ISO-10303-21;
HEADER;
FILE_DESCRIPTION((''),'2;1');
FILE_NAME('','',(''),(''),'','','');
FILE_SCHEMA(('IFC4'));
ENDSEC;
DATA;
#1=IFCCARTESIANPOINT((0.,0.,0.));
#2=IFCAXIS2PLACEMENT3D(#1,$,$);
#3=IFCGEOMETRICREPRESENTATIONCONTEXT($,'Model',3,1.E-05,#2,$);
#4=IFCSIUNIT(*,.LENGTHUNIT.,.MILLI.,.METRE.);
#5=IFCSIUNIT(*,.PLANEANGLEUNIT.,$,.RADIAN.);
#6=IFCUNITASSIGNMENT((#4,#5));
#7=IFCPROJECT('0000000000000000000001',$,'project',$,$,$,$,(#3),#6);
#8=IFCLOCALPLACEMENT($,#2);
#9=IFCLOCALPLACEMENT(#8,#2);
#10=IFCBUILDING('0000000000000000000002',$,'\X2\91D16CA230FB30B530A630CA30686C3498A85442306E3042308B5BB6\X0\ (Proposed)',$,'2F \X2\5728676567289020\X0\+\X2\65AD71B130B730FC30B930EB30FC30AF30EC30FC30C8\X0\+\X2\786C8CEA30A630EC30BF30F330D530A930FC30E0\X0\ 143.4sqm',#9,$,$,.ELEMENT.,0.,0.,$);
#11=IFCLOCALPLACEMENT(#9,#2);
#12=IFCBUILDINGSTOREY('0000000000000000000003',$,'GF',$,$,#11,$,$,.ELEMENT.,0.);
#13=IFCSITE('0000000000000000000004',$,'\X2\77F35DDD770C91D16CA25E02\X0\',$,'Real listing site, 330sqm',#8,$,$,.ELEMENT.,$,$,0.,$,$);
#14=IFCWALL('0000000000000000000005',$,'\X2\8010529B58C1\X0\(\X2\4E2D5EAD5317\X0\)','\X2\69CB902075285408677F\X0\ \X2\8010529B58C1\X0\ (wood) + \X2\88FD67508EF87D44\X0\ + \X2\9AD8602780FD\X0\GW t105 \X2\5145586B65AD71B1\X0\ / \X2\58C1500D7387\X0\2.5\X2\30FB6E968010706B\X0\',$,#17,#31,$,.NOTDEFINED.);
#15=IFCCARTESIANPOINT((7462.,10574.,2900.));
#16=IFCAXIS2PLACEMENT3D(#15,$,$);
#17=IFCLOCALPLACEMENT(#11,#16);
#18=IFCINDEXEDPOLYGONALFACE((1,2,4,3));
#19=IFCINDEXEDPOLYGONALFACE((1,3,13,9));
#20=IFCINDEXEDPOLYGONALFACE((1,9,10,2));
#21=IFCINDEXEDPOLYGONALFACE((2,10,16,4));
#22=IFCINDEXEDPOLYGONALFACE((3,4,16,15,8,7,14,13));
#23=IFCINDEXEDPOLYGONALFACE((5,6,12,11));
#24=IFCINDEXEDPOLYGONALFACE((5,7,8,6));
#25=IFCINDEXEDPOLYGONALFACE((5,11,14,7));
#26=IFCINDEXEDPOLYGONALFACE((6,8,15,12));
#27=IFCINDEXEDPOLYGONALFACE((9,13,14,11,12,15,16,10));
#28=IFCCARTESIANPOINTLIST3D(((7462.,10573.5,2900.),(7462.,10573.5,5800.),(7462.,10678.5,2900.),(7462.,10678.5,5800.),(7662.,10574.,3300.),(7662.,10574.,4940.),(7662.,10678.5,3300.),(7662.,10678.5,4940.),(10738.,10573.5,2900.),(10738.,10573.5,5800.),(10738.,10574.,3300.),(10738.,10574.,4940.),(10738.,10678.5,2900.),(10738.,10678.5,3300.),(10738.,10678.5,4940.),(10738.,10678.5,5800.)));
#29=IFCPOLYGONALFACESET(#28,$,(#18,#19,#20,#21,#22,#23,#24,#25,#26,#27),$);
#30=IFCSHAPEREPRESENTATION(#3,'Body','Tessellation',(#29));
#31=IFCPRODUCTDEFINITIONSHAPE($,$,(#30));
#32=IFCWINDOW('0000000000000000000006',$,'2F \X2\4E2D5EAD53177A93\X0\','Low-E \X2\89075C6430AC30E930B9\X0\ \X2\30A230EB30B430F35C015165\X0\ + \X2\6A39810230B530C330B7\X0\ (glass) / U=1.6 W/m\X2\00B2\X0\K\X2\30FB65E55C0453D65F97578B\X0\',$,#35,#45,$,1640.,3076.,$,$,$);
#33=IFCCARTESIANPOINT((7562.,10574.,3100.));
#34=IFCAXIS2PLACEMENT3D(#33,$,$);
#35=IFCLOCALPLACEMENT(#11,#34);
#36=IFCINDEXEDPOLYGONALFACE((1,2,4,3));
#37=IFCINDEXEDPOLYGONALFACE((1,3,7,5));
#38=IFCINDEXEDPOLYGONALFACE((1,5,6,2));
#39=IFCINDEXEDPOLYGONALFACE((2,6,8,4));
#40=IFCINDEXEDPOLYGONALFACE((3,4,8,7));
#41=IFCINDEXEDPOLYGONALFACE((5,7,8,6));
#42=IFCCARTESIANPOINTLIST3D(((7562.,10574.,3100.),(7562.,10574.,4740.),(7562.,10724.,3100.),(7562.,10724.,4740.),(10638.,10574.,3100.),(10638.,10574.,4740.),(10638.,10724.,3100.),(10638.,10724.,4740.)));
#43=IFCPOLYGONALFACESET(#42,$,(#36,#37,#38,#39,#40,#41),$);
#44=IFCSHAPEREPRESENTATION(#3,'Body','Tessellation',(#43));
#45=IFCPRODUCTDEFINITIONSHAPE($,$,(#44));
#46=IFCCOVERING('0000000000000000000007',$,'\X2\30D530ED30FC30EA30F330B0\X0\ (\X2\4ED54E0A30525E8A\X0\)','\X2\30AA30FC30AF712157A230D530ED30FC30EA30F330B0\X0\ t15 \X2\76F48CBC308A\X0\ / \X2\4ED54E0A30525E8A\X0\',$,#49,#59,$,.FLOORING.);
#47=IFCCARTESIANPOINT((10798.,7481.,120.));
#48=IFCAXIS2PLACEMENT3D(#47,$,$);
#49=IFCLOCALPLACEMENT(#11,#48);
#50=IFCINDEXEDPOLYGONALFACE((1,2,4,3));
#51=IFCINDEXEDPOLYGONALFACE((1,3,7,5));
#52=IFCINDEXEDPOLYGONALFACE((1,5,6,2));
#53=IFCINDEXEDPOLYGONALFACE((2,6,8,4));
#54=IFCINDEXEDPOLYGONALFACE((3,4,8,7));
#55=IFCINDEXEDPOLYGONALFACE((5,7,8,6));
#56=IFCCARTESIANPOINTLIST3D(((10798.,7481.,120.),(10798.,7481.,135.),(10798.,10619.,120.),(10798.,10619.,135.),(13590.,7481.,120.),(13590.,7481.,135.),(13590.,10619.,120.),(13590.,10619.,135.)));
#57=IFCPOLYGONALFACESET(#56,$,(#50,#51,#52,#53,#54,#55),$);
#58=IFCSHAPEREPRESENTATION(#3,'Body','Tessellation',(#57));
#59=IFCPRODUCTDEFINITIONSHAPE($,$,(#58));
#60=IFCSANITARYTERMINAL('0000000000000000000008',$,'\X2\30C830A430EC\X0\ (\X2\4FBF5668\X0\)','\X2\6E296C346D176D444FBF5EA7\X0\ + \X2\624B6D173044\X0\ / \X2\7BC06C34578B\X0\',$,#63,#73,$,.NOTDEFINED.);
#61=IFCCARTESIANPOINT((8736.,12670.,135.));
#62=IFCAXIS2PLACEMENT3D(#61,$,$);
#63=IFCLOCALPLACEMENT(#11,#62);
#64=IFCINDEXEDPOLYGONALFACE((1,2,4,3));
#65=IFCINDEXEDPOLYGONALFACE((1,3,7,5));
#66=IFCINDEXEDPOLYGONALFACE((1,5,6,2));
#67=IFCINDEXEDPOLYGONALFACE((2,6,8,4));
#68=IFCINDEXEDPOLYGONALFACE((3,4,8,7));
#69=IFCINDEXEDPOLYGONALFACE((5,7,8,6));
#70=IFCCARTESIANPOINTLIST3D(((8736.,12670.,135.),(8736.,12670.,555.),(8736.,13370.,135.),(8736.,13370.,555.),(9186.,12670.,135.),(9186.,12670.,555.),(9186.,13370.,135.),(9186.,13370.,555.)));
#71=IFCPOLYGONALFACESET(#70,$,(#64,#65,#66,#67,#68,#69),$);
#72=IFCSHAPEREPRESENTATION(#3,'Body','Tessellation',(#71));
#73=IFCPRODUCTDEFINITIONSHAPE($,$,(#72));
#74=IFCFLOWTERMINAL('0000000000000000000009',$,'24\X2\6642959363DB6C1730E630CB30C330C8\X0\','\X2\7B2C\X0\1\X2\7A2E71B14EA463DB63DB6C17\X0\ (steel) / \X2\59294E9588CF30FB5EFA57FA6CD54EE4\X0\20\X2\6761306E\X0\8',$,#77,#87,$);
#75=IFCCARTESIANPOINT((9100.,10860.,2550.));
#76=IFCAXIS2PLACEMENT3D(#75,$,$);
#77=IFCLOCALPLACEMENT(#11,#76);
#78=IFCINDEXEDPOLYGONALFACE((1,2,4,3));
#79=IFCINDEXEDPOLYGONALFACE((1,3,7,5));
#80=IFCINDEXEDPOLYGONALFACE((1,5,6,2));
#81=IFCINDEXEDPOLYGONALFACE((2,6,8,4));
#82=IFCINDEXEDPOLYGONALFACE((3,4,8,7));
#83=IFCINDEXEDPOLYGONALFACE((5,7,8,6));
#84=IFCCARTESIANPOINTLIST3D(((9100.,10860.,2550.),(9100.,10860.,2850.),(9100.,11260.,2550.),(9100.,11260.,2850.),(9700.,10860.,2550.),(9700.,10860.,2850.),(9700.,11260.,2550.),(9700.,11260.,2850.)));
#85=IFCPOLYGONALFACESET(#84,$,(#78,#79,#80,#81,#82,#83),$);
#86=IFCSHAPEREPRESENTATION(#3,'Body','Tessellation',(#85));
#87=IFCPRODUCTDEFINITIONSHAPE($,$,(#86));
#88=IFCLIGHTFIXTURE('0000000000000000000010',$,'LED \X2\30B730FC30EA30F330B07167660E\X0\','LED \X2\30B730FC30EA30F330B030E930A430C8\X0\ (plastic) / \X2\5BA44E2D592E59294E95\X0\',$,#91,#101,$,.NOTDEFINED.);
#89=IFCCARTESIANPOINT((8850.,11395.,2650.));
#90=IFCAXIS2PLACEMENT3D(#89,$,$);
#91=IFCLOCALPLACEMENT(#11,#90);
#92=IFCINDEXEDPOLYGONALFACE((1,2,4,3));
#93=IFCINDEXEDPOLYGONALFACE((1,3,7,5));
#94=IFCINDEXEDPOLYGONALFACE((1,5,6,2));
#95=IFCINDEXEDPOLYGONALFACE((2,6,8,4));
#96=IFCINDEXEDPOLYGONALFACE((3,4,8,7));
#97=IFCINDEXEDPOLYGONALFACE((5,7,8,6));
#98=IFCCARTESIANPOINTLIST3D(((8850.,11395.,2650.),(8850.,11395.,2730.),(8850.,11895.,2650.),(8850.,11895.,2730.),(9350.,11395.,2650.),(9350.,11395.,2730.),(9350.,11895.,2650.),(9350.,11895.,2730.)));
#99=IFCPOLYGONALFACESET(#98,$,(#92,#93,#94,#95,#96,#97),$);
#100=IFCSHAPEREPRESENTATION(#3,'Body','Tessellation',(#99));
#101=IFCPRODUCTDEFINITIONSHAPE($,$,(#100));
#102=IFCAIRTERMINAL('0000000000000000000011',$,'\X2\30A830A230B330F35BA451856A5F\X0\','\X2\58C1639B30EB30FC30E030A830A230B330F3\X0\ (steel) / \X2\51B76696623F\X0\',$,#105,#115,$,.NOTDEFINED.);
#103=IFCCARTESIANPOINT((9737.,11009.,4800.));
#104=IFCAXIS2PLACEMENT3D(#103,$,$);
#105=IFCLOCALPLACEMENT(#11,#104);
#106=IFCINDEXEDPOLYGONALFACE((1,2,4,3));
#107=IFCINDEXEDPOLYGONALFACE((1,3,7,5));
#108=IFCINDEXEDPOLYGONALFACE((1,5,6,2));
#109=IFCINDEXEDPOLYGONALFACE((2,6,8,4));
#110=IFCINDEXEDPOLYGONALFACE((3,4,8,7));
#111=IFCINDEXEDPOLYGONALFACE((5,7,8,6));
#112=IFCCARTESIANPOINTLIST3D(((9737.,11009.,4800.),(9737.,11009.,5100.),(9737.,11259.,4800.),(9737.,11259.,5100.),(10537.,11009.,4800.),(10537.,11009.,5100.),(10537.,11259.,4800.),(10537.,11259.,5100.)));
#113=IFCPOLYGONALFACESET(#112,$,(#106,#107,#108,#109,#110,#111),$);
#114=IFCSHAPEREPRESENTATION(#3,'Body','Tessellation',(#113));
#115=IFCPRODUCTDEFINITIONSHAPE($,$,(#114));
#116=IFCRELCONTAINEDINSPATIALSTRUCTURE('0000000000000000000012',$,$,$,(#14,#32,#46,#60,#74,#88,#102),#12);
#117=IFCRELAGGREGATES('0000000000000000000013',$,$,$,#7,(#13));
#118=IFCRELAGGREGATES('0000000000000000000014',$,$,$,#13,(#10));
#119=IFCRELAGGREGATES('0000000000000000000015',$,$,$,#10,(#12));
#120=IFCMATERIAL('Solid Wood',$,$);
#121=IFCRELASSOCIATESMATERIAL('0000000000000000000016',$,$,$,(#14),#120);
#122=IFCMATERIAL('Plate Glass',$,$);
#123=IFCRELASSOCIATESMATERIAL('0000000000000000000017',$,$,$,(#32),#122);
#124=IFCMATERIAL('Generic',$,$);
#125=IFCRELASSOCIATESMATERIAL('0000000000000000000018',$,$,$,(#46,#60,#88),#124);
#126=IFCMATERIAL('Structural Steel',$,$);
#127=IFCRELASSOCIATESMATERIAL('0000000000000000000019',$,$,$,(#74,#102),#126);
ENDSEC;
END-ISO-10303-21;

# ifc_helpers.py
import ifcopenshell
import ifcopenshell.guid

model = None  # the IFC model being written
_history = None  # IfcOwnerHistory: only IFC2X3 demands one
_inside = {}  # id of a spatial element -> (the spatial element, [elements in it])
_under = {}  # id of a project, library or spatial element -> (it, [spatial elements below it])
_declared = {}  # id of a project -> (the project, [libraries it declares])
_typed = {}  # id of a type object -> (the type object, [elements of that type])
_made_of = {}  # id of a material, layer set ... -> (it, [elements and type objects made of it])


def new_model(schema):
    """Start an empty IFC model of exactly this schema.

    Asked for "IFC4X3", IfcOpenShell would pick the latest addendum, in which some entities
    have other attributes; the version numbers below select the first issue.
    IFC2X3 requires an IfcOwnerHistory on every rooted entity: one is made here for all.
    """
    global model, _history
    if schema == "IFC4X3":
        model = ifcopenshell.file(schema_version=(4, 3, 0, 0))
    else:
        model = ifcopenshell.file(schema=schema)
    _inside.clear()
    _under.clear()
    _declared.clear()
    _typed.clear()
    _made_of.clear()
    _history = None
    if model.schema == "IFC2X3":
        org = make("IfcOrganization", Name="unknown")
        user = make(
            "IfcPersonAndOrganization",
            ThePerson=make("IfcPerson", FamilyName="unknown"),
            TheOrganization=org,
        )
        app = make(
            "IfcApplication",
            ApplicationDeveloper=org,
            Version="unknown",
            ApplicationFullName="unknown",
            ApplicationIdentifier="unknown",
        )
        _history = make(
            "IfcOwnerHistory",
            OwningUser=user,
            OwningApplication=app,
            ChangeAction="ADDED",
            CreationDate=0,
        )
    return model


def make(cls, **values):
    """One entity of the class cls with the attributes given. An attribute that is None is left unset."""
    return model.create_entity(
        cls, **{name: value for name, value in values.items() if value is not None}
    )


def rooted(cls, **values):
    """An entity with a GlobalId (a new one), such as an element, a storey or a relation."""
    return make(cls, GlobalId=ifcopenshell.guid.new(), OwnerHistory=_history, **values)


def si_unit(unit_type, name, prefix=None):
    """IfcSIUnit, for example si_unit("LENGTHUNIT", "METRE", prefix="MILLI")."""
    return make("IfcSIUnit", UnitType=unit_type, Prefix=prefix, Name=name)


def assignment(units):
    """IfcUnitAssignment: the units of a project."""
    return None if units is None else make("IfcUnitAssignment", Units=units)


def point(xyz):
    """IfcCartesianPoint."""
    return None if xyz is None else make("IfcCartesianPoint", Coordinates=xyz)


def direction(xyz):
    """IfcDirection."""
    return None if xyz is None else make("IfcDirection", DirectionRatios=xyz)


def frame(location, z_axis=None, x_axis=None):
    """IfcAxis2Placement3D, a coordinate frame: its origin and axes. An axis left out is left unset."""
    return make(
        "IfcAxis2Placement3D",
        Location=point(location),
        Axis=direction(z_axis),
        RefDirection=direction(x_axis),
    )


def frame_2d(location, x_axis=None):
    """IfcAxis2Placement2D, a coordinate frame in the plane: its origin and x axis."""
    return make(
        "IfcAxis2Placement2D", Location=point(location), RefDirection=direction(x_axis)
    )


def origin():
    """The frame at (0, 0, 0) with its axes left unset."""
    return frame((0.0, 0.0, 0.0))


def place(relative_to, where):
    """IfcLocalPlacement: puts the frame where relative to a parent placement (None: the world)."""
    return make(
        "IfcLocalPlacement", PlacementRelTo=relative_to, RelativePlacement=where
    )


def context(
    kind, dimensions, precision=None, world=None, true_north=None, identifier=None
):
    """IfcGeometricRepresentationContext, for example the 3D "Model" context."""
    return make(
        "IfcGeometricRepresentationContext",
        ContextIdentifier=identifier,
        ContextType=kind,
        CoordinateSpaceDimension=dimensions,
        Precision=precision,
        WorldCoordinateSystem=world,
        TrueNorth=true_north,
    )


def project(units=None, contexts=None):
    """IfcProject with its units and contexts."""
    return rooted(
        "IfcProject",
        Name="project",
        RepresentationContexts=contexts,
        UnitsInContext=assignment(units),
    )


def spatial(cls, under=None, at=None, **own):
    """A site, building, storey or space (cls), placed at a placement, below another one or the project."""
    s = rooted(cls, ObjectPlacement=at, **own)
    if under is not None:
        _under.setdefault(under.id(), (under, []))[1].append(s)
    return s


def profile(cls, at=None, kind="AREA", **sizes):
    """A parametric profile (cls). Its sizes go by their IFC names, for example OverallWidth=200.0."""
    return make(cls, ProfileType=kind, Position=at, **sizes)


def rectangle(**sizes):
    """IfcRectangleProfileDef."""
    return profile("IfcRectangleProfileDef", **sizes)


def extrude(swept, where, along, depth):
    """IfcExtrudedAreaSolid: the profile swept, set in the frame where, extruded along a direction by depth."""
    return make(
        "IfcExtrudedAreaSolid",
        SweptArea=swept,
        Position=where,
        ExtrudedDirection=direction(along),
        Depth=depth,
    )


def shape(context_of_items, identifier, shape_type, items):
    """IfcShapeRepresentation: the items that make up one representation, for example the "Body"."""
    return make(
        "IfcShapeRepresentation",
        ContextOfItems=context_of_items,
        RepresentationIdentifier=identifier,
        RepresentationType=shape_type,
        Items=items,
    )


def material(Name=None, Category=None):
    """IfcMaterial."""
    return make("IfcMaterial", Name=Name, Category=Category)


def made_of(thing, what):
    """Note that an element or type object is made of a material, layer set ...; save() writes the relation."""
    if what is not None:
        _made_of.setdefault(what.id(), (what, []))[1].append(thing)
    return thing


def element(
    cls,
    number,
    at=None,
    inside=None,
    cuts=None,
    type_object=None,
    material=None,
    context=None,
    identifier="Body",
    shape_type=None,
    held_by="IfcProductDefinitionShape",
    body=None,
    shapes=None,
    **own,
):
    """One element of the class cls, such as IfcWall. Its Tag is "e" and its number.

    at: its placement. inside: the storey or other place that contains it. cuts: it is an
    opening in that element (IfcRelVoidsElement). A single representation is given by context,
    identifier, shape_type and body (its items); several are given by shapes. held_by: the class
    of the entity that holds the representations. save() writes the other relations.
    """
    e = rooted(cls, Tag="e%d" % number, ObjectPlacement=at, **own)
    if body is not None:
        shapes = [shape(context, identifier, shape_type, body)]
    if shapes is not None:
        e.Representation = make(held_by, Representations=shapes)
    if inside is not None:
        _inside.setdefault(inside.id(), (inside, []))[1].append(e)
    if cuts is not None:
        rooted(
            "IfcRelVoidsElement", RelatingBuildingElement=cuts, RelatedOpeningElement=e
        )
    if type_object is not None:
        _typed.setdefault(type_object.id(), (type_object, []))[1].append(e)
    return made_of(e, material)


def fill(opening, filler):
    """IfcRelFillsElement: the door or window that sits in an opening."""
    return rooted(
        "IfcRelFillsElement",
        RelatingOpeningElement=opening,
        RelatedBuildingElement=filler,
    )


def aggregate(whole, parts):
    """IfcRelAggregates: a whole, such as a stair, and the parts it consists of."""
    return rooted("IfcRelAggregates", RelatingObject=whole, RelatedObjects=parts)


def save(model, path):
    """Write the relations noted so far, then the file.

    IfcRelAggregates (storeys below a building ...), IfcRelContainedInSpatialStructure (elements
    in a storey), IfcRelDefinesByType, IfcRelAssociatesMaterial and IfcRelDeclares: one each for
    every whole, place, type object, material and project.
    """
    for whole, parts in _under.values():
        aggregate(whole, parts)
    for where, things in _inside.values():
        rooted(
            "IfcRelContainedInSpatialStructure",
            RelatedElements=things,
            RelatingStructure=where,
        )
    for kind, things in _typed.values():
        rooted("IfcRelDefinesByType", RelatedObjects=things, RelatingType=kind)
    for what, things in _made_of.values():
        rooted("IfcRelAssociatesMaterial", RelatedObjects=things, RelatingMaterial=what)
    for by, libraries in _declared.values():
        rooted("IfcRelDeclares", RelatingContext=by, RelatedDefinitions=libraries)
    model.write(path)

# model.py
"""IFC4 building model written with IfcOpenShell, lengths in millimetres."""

from ifc_helpers import new_model, si_unit, frame, frame_2d, origin, place, context, project, spatial, rectangle, extrude, material, element, fill, save


model = new_model("IFC4")

# Units and contexts
model_context = context("Model", 3, precision=1e-05, world=origin())
ifc_project = project(units=[si_unit("LENGTHUNIT", "METRE", prefix="MILLI"), si_unit("PLANEANGLEUNIT", "RADIAN")], contexts=[model_context])

# Site, building, storey
site_placement = place(None, origin())
site = spatial("IfcSite", under=ifc_project, at=site_placement, Name="石川県金沢市", ObjectType="Real listing site, 330sqm", CompositionType="ELEMENT", RefElevation=0.0)
building_placement = place(site_placement, origin())
building = spatial("IfcBuilding", under=site, at=building_placement, Name="金沢・サウナと水風呂のある家 (Proposed)", ObjectType="2F 在来木造+断熱シースルークレート+硬質ウレタンフォーム 143.4sqm", CompositionType="ELEMENT", ElevationOfRefHeight=0.0, ElevationOfTerrain=0.0)
storey_placement = place(building_placement, origin())
storey = spatial("IfcBuildingStorey", under=building, at=storey_placement, Name="GF", CompositionType="ELEMENT", Elevation=0.0)

# Shared definitions
ifc_material_1 = material(Name="Solid Wood")

# Shared definitions
ifc_material_2 = material(Name="Plate Glass")

# Wall, opening, window
wall_1_placement = place(storey_placement, frame((7462.0, 10574.0, 2900.0)))
wall_1 = element("IfcWall", 1, at=wall_1_placement, inside=storey, material=ifc_material_1, Name="耐力壁(中庭北)", Description="構造用合板 耐力壁 (wood) + 製材軸組 + 高性能GW t105 充填断熱 / 壁倍率2.5・準耐火", PredefinedType="NOTDEFINED", context=model_context, shape_type="SweptSolid", body=[
    extrude(rectangle(XDim=3276.0, YDim=105.0, at=frame_2d((1638.0, 52.0))), frame((7462.0, 10574.0, 2900.0)), (0.0, 0.0, 1.0), 2900.0),
])
opening_1_placement = place(storey_placement, frame((7562.0, 10574.0, 3100.0)))
opening_1 = element("IfcOpeningElement", 2, at=opening_1_placement, cuts=wall_1, PredefinedType="NOTDEFINED", context=model_context, shape_type="SweptSolid", body=[
    extrude(rectangle(XDim=3076.0, YDim=150.0, at=frame_2d((1538.0, 75.0))), frame((7562.0, 10574.0, 3100.0)), (0.0, 0.0, 1.0), 1640.0),
])
window_1_placement = place(storey_placement, frame((7562.0, 10574.0, 3100.0)))
window_1 = element("IfcWindow", 3, at=window_1_placement, inside=storey, material=ifc_material_2, Name="2F 中庭北窓", Description="Low-E 複層ガラス アルゴン封入 + 樹脂サッシ (glass) / U=1.6 W/m²K・日射取得型", OverallHeight=1640.0, OverallWidth=3076.0, context=model_context, shape_type="SweptSolid", body=[
    extrude(rectangle(XDim=3076.0, YDim=150.0, at=frame_2d((1538.0, 75.0))), frame((7562.0, 10574.0, 3100.0)), (0.0, 0.0, 1.0), 1640.0),
])
fill(opening_1, window_1)

# Covering
ifc_material_3 = material(Name="Generic")
covering_placement = place(storey_placement, frame((10798.0, 7481.0, 120.0)))
element("IfcCovering", 4, at=covering_placement, inside=storey, material=ifc_material_3, Name="フローリング (仕上げ床)", Description="オーク無垢フローリング t15 直貼り / 仕上げ床", PredefinedType="FLOORING", context=model_context, shape_type="SweptSolid", body=[
    extrude(rectangle(XDim=2792.0, YDim=3138.0, at=frame_2d((1396.0, 1569.0))), frame((10798.0, 7481.0, 120.0)), (0.0, 0.0, 1.0), 15.0),
])

# Sanitary terminal
sanitary_terminal_placement = place(storey_placement, frame((8736.0, 12670.0, 135.0)))
element("IfcSanitaryTerminal", 5, at=sanitary_terminal_placement, inside=storey, material=ifc_material_3, Name="トイレ (便器)", Description="温水洗浄便座 + 手洗い / 節水型", PredefinedType="NOTDEFINED", context=model_context, shape_type="SweptSolid", body=[
    extrude(rectangle(XDim=450.0, YDim=700.0, at=frame_2d((225.0, 350.0))), frame((8736.0, 12670.0, 135.0)), (0.0, 0.0, 1.0), 420.0),
])

# Flow terminal
ifc_material_4 = material(Name="Structural Steel")
flow_terminal_placement = place(storey_placement, frame((9100.0, 10860.0, 2550.0)))
element("IfcFlowTerminal", 6, at=flow_terminal_placement, inside=storey, material=ifc_material_4, Name="24時間換気ユニット", Description="第1種熱交換換気 (steel) / 天井裏・建基法令20条の8", context=model_context, shape_type="SweptSolid", body=[
    extrude(rectangle(XDim=600.0, YDim=400.0, at=frame_2d((300.0, 200.0))), frame((9100.0, 10860.0, 2550.0)), (0.0, 0.0, 1.0), 300.0),
])

# Light fixture
light_fixture_placement = place(storey_placement, frame((8850.0, 11395.0, 2650.0)))
element("IfcLightFixture", 7, at=light_fixture_placement, inside=storey, material=ifc_material_3, Name="LED シーリング照明", Description="LED シーリングライト (plastic) / 室中央天井", PredefinedType="NOTDEFINED", context=model_context, shape_type="SweptSolid", body=[
    extrude(rectangle(XDim=500.0, YDim=500.0, at=frame_2d((250.0, 250.0))), frame((8850.0, 11395.0, 2650.0)), (0.0, 0.0, 1.0), 80.0),
])

# Air terminal
air_terminal_placement = place(storey_placement, frame((9737.0, 11009.0, 4800.0)))
element("IfcAirTerminal", 8, at=air_terminal_placement, inside=storey, material=ifc_material_4, Name="エアコン室内機", Description="壁掛ルームエアコン (steel) / 冷暖房", PredefinedType="NOTDEFINED", context=model_context, shape_type="SweptSolid", body=[
    extrude(rectangle(XDim=800.0, YDim=250.0, at=frame_2d((400.0, 125.0))), frame((9737.0, 11009.0, 4800.0)), (0.0, 0.0, 1.0), 300.0),
])

save(model, "model.ifc")
